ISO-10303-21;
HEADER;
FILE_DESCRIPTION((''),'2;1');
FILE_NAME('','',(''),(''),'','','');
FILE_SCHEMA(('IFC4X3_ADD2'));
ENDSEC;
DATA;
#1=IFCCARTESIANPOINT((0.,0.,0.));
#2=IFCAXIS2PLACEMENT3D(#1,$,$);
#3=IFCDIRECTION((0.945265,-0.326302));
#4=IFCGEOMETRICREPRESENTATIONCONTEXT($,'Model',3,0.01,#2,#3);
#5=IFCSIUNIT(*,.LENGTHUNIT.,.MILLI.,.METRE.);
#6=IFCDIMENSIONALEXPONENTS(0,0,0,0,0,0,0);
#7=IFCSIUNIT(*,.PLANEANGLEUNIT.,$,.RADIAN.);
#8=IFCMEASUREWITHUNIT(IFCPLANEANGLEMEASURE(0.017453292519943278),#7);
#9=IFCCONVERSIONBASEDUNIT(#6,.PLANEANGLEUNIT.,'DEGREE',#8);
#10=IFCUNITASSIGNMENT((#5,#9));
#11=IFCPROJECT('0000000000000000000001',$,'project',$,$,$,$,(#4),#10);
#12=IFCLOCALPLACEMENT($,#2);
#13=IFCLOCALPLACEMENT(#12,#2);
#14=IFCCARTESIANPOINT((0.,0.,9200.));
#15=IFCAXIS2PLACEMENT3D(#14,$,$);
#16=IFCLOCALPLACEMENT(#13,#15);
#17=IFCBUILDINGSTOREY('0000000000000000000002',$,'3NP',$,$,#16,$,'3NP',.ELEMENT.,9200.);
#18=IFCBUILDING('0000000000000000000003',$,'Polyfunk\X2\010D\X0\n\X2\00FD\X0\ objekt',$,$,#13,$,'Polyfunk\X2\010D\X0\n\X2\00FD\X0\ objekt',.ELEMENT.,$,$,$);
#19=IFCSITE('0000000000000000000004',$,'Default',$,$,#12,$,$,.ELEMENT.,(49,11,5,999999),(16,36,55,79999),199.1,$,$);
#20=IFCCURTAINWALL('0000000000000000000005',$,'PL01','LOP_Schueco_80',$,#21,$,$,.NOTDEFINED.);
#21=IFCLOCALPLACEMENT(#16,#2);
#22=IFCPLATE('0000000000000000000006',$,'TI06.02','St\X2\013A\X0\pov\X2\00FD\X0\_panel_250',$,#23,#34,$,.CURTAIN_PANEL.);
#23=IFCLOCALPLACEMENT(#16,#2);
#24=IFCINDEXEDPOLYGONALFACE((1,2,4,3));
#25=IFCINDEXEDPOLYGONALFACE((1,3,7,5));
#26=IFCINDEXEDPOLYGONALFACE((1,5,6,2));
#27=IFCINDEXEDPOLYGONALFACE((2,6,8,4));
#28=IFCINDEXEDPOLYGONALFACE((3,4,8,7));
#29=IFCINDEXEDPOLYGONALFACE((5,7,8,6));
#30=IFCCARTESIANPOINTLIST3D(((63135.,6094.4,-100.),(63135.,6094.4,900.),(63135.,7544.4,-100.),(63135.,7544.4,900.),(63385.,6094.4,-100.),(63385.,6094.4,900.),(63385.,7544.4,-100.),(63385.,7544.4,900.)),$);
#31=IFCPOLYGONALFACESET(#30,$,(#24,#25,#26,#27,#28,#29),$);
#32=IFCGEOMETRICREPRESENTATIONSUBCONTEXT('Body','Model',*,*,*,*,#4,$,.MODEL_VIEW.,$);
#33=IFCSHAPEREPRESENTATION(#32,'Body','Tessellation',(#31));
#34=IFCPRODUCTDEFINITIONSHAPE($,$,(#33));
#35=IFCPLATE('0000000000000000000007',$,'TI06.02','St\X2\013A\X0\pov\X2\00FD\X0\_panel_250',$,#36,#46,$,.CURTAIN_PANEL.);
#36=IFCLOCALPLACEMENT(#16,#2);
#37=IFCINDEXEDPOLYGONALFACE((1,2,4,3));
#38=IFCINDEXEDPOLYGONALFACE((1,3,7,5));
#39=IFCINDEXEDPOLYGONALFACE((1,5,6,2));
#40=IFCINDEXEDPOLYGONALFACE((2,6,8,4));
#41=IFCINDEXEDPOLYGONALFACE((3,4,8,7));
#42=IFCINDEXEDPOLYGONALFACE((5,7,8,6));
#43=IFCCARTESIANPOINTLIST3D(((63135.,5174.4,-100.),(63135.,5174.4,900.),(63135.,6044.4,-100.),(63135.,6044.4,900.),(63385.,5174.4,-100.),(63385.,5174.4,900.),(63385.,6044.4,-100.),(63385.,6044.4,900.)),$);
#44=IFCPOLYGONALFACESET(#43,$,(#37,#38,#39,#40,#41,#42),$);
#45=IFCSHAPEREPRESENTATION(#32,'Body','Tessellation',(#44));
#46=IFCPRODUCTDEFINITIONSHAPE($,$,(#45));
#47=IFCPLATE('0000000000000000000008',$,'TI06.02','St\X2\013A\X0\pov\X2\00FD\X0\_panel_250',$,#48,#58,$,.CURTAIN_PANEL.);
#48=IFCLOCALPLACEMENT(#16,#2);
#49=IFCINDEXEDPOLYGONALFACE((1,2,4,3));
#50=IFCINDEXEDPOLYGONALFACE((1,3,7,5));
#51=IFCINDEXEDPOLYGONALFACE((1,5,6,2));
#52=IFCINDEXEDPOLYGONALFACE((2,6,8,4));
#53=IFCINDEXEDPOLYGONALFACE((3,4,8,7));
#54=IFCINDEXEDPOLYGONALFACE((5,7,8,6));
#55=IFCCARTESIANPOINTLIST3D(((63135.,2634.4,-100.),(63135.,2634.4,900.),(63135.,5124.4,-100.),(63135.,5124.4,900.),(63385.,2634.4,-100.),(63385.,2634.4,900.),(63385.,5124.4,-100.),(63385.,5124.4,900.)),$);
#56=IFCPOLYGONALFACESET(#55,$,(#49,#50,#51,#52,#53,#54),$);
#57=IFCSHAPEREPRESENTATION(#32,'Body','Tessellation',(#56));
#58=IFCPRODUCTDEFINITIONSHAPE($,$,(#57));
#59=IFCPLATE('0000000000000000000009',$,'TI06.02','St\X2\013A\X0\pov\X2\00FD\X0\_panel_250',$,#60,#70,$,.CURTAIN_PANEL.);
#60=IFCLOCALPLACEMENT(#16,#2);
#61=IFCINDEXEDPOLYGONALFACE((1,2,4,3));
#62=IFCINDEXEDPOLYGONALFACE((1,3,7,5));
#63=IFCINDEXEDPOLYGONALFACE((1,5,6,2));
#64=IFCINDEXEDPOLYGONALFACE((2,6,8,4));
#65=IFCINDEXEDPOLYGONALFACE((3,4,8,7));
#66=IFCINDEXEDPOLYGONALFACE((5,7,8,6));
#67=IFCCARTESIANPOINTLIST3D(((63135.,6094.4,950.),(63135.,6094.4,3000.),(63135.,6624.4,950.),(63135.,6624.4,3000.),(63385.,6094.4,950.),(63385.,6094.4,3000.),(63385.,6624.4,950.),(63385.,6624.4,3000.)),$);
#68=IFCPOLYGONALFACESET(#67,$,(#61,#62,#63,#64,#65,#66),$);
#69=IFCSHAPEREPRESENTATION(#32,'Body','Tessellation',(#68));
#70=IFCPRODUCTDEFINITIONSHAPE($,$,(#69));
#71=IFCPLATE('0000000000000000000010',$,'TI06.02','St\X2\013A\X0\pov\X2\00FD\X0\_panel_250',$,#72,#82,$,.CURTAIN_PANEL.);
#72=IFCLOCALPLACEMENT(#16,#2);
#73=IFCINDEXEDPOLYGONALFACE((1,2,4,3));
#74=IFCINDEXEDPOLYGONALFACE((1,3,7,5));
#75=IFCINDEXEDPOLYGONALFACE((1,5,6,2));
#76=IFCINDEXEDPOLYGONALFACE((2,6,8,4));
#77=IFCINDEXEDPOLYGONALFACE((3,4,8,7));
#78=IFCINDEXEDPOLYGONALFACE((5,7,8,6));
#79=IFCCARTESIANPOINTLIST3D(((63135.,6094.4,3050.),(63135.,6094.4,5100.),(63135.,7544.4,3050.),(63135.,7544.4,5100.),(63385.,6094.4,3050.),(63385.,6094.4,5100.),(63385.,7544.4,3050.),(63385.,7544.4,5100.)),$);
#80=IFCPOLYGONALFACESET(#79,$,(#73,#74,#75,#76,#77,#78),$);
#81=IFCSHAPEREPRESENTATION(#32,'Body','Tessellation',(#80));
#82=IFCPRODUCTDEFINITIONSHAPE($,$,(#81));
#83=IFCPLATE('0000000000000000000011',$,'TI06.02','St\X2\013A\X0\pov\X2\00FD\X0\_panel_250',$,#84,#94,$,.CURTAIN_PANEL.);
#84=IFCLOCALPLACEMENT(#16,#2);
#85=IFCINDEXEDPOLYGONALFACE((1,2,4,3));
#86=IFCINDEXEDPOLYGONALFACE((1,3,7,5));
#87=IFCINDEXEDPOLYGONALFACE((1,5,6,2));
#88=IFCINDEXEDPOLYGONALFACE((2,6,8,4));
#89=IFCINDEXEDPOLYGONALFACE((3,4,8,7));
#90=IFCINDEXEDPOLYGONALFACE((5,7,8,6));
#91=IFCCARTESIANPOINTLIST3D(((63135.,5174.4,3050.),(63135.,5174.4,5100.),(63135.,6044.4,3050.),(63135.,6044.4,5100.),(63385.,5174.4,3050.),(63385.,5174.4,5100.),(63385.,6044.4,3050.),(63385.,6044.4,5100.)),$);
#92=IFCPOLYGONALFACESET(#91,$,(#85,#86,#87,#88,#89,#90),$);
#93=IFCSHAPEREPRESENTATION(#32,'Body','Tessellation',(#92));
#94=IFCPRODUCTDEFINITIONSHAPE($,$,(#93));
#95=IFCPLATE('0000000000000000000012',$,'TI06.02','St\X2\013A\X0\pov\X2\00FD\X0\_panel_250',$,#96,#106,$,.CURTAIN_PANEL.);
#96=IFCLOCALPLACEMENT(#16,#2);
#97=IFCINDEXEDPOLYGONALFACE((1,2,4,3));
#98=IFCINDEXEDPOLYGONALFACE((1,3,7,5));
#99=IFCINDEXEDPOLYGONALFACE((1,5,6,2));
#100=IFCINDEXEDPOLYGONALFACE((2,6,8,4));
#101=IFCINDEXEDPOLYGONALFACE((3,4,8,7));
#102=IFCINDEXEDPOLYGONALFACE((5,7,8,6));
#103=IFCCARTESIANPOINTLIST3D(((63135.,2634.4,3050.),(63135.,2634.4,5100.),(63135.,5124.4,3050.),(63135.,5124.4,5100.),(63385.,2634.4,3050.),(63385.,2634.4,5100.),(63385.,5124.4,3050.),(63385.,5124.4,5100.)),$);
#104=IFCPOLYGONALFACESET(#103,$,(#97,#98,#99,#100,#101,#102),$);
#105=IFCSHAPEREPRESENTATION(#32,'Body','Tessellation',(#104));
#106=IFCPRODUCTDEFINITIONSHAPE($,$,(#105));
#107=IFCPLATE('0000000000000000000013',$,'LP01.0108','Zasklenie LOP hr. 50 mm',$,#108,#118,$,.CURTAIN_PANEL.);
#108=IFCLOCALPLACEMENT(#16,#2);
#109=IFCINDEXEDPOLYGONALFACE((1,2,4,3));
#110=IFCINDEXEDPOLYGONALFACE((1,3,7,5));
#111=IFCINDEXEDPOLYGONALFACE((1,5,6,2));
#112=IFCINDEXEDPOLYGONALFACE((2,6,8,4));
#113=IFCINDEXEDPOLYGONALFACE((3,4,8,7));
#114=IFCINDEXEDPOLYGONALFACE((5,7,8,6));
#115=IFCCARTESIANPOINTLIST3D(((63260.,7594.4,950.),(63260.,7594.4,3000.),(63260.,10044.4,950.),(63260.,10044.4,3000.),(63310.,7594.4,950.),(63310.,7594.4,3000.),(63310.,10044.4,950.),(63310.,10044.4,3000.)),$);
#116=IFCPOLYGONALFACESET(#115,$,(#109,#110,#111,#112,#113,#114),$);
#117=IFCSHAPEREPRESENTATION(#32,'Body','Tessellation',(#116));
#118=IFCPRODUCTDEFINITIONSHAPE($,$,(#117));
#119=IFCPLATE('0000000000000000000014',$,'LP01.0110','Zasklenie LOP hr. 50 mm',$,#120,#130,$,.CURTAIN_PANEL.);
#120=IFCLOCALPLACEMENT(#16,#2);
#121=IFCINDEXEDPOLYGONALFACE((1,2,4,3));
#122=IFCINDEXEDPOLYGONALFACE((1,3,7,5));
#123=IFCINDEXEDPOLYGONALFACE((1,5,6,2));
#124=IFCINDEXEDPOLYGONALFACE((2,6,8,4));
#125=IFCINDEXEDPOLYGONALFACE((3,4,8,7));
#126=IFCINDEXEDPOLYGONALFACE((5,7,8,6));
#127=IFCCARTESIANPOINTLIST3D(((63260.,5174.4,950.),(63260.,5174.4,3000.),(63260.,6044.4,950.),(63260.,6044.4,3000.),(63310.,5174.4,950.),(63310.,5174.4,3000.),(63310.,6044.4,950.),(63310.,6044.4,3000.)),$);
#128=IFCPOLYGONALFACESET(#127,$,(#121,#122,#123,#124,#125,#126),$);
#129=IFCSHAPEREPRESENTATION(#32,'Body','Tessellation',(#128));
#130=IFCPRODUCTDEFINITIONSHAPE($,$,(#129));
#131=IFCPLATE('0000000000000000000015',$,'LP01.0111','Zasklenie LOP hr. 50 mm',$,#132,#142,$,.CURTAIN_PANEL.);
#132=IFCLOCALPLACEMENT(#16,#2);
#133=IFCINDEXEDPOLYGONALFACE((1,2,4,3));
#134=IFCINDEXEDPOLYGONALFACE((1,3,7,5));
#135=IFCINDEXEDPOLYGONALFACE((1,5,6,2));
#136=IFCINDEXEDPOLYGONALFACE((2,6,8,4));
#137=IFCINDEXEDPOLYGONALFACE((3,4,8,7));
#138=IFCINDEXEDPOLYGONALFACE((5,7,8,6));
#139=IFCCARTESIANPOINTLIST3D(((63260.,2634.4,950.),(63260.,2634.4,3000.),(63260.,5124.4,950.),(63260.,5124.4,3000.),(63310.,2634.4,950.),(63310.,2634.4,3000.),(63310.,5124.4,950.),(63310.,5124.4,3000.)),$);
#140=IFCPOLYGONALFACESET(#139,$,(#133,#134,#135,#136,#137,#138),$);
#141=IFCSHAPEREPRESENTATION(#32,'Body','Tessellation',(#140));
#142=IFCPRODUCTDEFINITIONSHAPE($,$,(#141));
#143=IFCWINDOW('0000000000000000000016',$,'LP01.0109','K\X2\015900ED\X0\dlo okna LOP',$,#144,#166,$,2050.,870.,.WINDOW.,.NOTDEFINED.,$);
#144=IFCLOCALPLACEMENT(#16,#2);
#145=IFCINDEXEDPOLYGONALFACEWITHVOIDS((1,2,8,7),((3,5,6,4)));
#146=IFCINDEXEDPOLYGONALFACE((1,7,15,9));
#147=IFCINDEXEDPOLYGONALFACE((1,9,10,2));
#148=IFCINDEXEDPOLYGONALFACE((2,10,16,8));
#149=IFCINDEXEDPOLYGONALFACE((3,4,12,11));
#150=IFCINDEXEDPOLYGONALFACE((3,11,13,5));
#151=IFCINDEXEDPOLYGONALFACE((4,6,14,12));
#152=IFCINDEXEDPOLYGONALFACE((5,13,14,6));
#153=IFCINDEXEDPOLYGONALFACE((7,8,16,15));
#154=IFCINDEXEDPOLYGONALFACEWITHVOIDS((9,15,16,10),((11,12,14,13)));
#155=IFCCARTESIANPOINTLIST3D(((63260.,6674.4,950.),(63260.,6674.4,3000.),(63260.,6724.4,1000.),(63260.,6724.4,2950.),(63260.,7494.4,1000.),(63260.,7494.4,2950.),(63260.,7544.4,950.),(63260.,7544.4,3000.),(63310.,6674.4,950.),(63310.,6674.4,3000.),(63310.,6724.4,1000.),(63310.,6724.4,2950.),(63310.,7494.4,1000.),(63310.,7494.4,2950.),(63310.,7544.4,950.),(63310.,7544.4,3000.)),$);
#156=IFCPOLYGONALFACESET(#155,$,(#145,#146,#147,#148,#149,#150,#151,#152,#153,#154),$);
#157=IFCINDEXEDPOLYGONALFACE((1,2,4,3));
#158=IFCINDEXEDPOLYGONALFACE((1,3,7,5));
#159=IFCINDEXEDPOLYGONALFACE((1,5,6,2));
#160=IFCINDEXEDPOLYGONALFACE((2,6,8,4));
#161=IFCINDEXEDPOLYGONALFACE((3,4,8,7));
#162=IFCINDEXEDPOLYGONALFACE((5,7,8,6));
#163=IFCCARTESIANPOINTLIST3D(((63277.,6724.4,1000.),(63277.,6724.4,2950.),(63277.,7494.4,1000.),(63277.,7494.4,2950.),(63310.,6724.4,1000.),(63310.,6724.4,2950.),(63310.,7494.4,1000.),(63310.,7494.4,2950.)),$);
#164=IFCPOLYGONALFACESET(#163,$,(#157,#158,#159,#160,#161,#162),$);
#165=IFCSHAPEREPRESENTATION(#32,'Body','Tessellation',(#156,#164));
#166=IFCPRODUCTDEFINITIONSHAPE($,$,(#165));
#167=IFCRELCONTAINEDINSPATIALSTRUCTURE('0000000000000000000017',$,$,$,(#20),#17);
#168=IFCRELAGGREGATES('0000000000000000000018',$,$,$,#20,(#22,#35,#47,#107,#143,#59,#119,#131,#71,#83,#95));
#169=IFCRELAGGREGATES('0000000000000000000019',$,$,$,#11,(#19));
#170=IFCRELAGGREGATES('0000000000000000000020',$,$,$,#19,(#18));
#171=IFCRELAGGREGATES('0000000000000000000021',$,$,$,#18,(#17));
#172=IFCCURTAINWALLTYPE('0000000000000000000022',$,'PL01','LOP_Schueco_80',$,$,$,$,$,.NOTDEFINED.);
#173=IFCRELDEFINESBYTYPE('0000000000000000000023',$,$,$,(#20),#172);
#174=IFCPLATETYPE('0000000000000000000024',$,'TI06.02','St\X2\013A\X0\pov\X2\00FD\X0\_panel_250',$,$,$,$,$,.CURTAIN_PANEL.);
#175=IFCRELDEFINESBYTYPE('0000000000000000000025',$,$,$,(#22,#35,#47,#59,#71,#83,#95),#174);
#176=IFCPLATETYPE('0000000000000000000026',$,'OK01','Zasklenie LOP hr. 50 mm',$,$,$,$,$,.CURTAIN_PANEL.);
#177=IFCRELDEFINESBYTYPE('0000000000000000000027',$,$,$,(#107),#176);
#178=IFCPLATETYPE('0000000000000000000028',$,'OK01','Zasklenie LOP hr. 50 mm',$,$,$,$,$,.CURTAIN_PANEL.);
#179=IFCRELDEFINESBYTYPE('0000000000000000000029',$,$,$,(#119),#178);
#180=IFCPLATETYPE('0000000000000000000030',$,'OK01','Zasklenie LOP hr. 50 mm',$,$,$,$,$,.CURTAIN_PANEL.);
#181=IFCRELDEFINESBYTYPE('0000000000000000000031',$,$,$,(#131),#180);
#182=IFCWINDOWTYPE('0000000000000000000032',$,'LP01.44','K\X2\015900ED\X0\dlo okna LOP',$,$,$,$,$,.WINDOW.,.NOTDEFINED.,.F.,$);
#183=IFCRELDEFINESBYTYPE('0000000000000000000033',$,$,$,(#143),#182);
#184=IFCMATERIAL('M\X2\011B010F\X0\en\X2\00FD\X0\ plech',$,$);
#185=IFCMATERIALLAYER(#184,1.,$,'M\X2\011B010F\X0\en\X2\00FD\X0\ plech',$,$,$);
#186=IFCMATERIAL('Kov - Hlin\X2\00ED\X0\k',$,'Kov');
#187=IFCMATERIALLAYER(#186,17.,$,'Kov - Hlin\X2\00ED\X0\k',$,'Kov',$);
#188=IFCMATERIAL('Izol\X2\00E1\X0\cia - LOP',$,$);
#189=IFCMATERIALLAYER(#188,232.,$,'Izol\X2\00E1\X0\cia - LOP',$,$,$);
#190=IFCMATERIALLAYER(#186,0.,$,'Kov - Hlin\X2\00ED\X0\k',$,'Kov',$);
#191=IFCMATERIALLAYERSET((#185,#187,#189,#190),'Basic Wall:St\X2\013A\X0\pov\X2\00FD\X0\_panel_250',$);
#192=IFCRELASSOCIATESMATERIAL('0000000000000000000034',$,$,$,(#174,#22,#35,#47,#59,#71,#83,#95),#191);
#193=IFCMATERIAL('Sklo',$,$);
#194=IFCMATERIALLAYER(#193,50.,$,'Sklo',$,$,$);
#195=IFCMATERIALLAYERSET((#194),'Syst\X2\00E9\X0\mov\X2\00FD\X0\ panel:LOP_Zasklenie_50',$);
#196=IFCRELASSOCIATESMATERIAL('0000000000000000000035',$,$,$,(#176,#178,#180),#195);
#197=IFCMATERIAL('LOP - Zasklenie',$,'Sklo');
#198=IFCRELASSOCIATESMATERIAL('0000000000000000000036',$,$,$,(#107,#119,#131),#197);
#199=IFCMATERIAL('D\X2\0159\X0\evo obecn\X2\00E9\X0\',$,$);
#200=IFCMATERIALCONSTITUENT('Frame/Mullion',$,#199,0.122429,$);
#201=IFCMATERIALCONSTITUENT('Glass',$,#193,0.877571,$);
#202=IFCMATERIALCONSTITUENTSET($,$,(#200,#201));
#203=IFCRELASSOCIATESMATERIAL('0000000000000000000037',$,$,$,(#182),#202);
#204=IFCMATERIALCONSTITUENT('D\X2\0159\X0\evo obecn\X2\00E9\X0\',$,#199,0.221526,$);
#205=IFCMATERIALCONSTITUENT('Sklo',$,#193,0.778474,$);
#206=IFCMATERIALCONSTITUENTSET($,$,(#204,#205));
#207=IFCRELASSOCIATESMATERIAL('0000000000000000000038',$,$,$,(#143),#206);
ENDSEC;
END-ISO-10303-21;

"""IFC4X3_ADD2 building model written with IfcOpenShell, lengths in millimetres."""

from ifc_helpers import new_model, entity, si_unit, converted_unit, direction, frame, frame_2d, origin, origin_2d_with_axis, place, context, subcontext, project, spatial, polyline, rectangle, outline, extrude, source, transform, mapped, material, layer, layer_set, layer_usage, constituent, constituent_set, type_object, type_shapes, element, aggregate, save


model = new_model("IFC4X3_ADD2")

# Units and contexts
model_context = context("Model", 3, precision=0.01, world=origin(), true_north=direction((0.945265, -0.326302)))
body_context = subcontext(model_context, "Body", "Model", "MODEL_VIEW")
ifc_project = project(units=[si_unit("LENGTHUNIT", "METRE", prefix="MILLI"), converted_unit("PLANEANGLEUNIT", "DEGREE", entity("IfcPlaneAngleMeasure", 0.017453292519943278), si_unit("PLANEANGLEUNIT", "RADIAN"), dimensions=[0, 0, 0, 0, 0, 0, 0])], contexts=[model_context])

# Site, building, storey
site_placement = place(None, origin())
site = spatial("IfcSite", under=ifc_project, at=site_placement, Name="Default", CompositionType="ELEMENT", RefLatitude=(49, 11, 5, 999999), RefLongitude=(16, 36, 55, 79999), RefElevation=199.1)
building_placement = place(site_placement, origin())
building = spatial("IfcBuilding", under=site, at=building_placement, Name="Polyfunkčný objekt", LongName="Polyfunkčný objekt", CompositionType="ELEMENT")
storey_placement = place(building_placement, frame((0.0, 0.0, 9200.0)))
storey = spatial("IfcBuildingStorey", under=building, at=storey_placement, Name="3NP", LongName="3NP", CompositionType="ELEMENT", Elevation=9200.0)

# Curtain wall, plates, window
curtain_wall_type = type_object("IfcCurtainWallType", Name="PL01", Description="LOP_Schueco_80", PredefinedType="NOTDEFINED")
curtain_wall_placement = place(storey_placement, frame((0.0, 0.0, -9200.0)))
curtain_wall = element("IfcCurtainWall", 1, at=curtain_wall_placement, inside=storey, type_object=curtain_wall_type, Name="PL01", Description="LOP_Schueco_80", PredefinedType="NOTDEFINED")
ifc_material_1 = material(Name="Měďený plech")
ifc_layer_1 = layer(ifc_material_1, 1.0, Name="Měďený plech")
ifc_material_2 = material(Name="Kov - Hliník", Category="Kov")
ifc_layer_2 = layer(ifc_material_2, 17.0, Name="Kov - Hliník", Category="Kov")
ifc_material_3 = material(Name="Izolácia - LOP")
ifc_layer_3 = layer(ifc_material_3, 232.0, Name="Izolácia - LOP")
ifc_layer_4 = layer(ifc_material_2, 0.0, Name="Kov - Hliník", Category="Kov")
ifc_layer_set_1 = layer_set([ifc_layer_1, ifc_layer_2, ifc_layer_3, ifc_layer_4], Name="Basic Wall:Stĺpový_panel_250")
ifc_layer_usage_1 = layer_usage(ifc_layer_set_1, "AXIS2", "NEGATIVE", 125.0)
plate_type_1 = type_object("IfcPlateType", Name="TI06.02", Description="Stĺpový_panel_250", PredefinedType="CURTAIN_PANEL", material=ifc_layer_set_1)
plate_1_placement = place(storey_placement, frame((63260.0, 7544.4, -100.0), z_axis=(0.0, 0.0, 1.0), x_axis=(0.0, -1.0, 0.0)))
plate_1 = element("IfcPlate", 2, at=plate_1_placement, type_object=plate_type_1, material=ifc_layer_usage_1, Name="TI06.02", Description="Stĺpový_panel_250", PredefinedType="CURTAIN_PANEL", context=body_context, shape_type="SweptSolid", body=[
    extrude(rectangle(XDim=250.0, YDim=1450.0, at=frame_2d((0.0, 0.0), x_axis=(1.0, 0.0))), frame((725.0, 0.0, 0.0), z_axis=(0.0, 0.0, 1.0), x_axis=(0.0, 1.0, 0.0)), (0.0, 0.0, 1.0), 1000.0),
])
ifc_layer_usage_2 = layer_usage(ifc_layer_set_1, "AXIS2", "NEGATIVE", 125.0)
plate_2_placement = place(storey_placement, frame((63260.0, 6044.4, -100.0), z_axis=(0.0, 0.0, 1.0), x_axis=(0.0, -1.0, 0.0)))
plate_2 = element("IfcPlate", 3, at=plate_2_placement, type_object=plate_type_1, material=ifc_layer_usage_2, Name="TI06.02", Description="Stĺpový_panel_250", PredefinedType="CURTAIN_PANEL", context=body_context, shape_type="SweptSolid", body=[
    extrude(rectangle(XDim=250.0, YDim=870.0, at=frame_2d((0.0, 0.0), x_axis=(1.0, 0.0))), frame((435.0, 0.0, 0.0), z_axis=(0.0, 0.0, 1.0), x_axis=(0.0, 1.0, 0.0)), (0.0, 0.0, 1.0), 1000.0),
])
ifc_layer_usage_3 = layer_usage(ifc_layer_set_1, "AXIS2", "NEGATIVE", 125.0)
plate_3_placement = place(storey_placement, frame((63260.0, 5124.4, -100.0), z_axis=(0.0, 0.0, 1.0), x_axis=(0.0, -1.0, 0.0)))
plate_3 = element("IfcPlate", 4, at=plate_3_placement, type_object=plate_type_1, material=ifc_layer_usage_3, Name="TI06.02", Description="Stĺpový_panel_250", PredefinedType="CURTAIN_PANEL", context=body_context, shape_type="SweptSolid", body=[
    extrude(rectangle(XDim=250.0, YDim=2490.0, at=origin_2d_with_axis()), frame((1245.0, 0.0, 0.0), z_axis=(0.0, 0.0, 1.0), x_axis=(0.0, 1.0, 0.0)), (0.0, 0.0, 1.0), 1000.0),
])
ifc_layer_usage_4 = layer_usage(ifc_layer_set_1, "AXIS2", "NEGATIVE", 125.0)
plate_4_placement = place(storey_placement, frame((63260.0, 6624.4, 950.0), z_axis=(0.0, 0.0, 1.0), x_axis=(0.0, -1.0, 0.0)))
plate_4 = element("IfcPlate", 5, at=plate_4_placement, type_object=plate_type_1, material=ifc_layer_usage_4, Name="TI06.02", Description="Stĺpový_panel_250", PredefinedType="CURTAIN_PANEL", context=body_context, shape_type="SweptSolid", body=[
    extrude(rectangle(XDim=250.0, YDim=530.0, at=frame_2d((0.0, 0.0), x_axis=(1.0, 0.0))), frame((265.0, 0.0, 0.0), z_axis=(0.0, 0.0, 1.0), x_axis=(0.0, 1.0, 0.0)), (0.0, 0.0, 1.0), 2050.0),
])
ifc_layer_usage_5 = layer_usage(ifc_layer_set_1, "AXIS2", "NEGATIVE", 125.0)
plate_5_placement = place(storey_placement, frame((63260.0, 7544.4, 3050.0), z_axis=(0.0, 0.0, 1.0), x_axis=(0.0, -1.0, 0.0)))
plate_5 = element("IfcPlate", 6, at=plate_5_placement, type_object=plate_type_1, material=ifc_layer_usage_5, Name="TI06.02", Description="Stĺpový_panel_250", PredefinedType="CURTAIN_PANEL", context=body_context, shape_type="SweptSolid", body=[
    extrude(rectangle(XDim=250.0, YDim=1450.0, at=frame_2d((0.0, 0.0), x_axis=(1.0, 0.0))), frame((725.0, 0.0, 0.0), z_axis=(0.0, 0.0, 1.0), x_axis=(0.0, 1.0, 0.0)), (0.0, 0.0, 1.0), 2050.0),
])
ifc_layer_usage_6 = layer_usage(ifc_layer_set_1, "AXIS2", "NEGATIVE", 125.0)
plate_6_placement = place(storey_placement, frame((63260.0, 6044.4, 3050.0), z_axis=(0.0, 0.0, 1.0), x_axis=(0.0, -1.0, 0.0)))
plate_6 = element("IfcPlate", 7, at=plate_6_placement, type_object=plate_type_1, material=ifc_layer_usage_6, Name="TI06.02", Description="Stĺpový_panel_250", PredefinedType="CURTAIN_PANEL", context=body_context, shape_type="SweptSolid", body=[
    extrude(rectangle(XDim=250.0, YDim=870.0, at=frame_2d((0.0, 0.0), x_axis=(1.0, 0.0))), frame((435.0, 0.0, 0.0), z_axis=(0.0, 0.0, 1.0), x_axis=(0.0, 1.0, 0.0)), (0.0, 0.0, 1.0), 2050.0),
])
ifc_layer_usage_7 = layer_usage(ifc_layer_set_1, "AXIS2", "NEGATIVE", 125.0)
plate_7_placement = place(storey_placement, frame((63260.0, 5124.4, 3050.0), z_axis=(0.0, 0.0, 1.0), x_axis=(0.0, -1.0, 0.0)))
plate_7 = element("IfcPlate", 8, at=plate_7_placement, type_object=plate_type_1, material=ifc_layer_usage_7, Name="TI06.02", Description="Stĺpový_panel_250", PredefinedType="CURTAIN_PANEL", context=body_context, shape_type="SweptSolid", body=[
    extrude(rectangle(XDim=250.0, YDim=2490.0, at=frame_2d((0.0, 0.0), x_axis=(1.0, 0.0))), frame((1245.0, 0.0, 0.0), z_axis=(0.0, 0.0, 1.0), x_axis=(0.0, 1.0, 0.0)), (0.0, 0.0, 1.0), 2050.0),
])
ifc_material_4 = material(Name="LOP - Zasklenie", Category="Sklo")
ifc_material_5 = material(Name="Sklo")
ifc_layer_5 = layer(ifc_material_5, 50.0, Name="Sklo")
ifc_layer_set_2 = layer_set([ifc_layer_5], Name="Systémový panel:LOP_Zasklenie_50")
plate_type_2 = type_object("IfcPlateType", Name="OK01", Description="Zasklenie LOP hr. 50 mm", PredefinedType="CURTAIN_PANEL", material=ifc_layer_set_2)
shared_shape_1 = source(origin(), body_context, "Body", "SweptSolid", [
    extrude(rectangle(XDim=50.0, YDim=2450.0, at=origin_2d_with_axis()), frame((0.0, 25.0, 0.0), z_axis=(0.0, 0.0, 1.0), x_axis=(0.0, 1.0, 0.0)), (0.0, 0.0, 1.0), 2050.0),
])
type_shapes(plate_type_2, [shared_shape_1])
plate_8_placement = place(curtain_wall_placement, frame((63260.0, 8819.4, 10150.0), z_axis=(0.0, 0.0, 1.0), x_axis=(0.0, -1.0, 0.0)))
plate_8 = element("IfcPlate", 9, at=plate_8_placement, type_object=plate_type_2, material=ifc_material_4, Name="LP01.0108", Description="Zasklenie LOP hr. 50 mm", PredefinedType="CURTAIN_PANEL", context=body_context, shape_type="MappedRepresentation", body=[
    mapped(shared_shape_1, transform((0.0, 0.0, 0.0), scale=1.0)),
])
plate_type_3 = type_object("IfcPlateType", Name="OK01", Description="Zasklenie LOP hr. 50 mm", PredefinedType="CURTAIN_PANEL", material=ifc_layer_set_2)
shared_shape_2 = source(origin(), body_context, "Body", "SweptSolid", [
    extrude(rectangle(XDim=50.0, YDim=870.0, at=origin_2d_with_axis()), frame((0.0, 25.0, 0.0), z_axis=(0.0, 0.0, 1.0), x_axis=(0.0, 1.0, 0.0)), (0.0, 0.0, 1.0), 2050.0),
])
type_shapes(plate_type_3, [shared_shape_2])
plate_9_placement = place(curtain_wall_placement, frame((63260.0, 5609.4, 10150.0), z_axis=(0.0, 0.0, 1.0), x_axis=(0.0, -1.0, 0.0)))
plate_9 = element("IfcPlate", 10, at=plate_9_placement, type_object=plate_type_3, material=ifc_material_4, Name="LP01.0110", Description="Zasklenie LOP hr. 50 mm", PredefinedType="CURTAIN_PANEL", context=body_context, shape_type="MappedRepresentation", body=[
    mapped(shared_shape_2, transform((0.0, 0.0, 0.0), scale=1.0)),
])
plate_type_4 = type_object("IfcPlateType", Name="OK01", Description="Zasklenie LOP hr. 50 mm", PredefinedType="CURTAIN_PANEL", material=ifc_layer_set_2)
shared_shape_3 = source(origin(), body_context, "Body", "SweptSolid", [
    extrude(rectangle(XDim=50.0, YDim=2490.0, at=origin_2d_with_axis()), frame((0.0, 25.0, 0.0), z_axis=(0.0, 0.0, 1.0), x_axis=(0.0, 1.0, 0.0)), (0.0, 0.0, 1.0), 2050.0),
])
type_shapes(plate_type_4, [shared_shape_3])
plate_10_placement = place(curtain_wall_placement, frame((63260.0, 3879.4, 10150.0), z_axis=(0.0, 0.0, 1.0), x_axis=(0.0, -1.0, 0.0)))
plate_10 = element("IfcPlate", 11, at=plate_10_placement, type_object=plate_type_4, material=ifc_material_4, Name="LP01.0111", Description="Zasklenie LOP hr. 50 mm", PredefinedType="CURTAIN_PANEL", context=body_context, shape_type="MappedRepresentation", body=[
    mapped(shared_shape_3, transform((0.0, 0.0, 0.0), scale=1.0)),
])
ifc_material_6 = material(Name="Dřevo obecné")
ifc_constituent_1 = constituent(ifc_material_6, Name="Dřevo obecné", fraction=0.221526)
ifc_constituent_2 = constituent(ifc_material_5, Name="Sklo", fraction=0.778474)
ifc_constituent_set_1 = constituent_set(constituents=[ifc_constituent_1, ifc_constituent_2])
ifc_constituent_3 = constituent(ifc_material_6, Name="Frame/Mullion", fraction=0.122429)
ifc_constituent_4 = constituent(ifc_material_5, Name="Glass", fraction=0.877571)
ifc_constituent_set_2 = constituent_set(constituents=[ifc_constituent_3, ifc_constituent_4])
window_type = type_object("IfcWindowType", Name="LP01.44", Description="Křídlo okna LOP", ParameterTakesPrecedence=False, PartitioningType="NOTDEFINED", PredefinedType="WINDOW", material=ifc_constituent_set_2)
shared_shape_4 = source(origin(), body_context, "Body", "SweptSolid", [
    extrude(outline(polyline([(-1025.0, -435.0), (1025.0, -435.0), (1025.0, 435.0), (-1025.0, 435.0), (-1025.0, -435.0)]), holes=[polyline([(-975.0, -385.0), (-975.0, 385.0), (975.0, 385.0), (975.0, -385.0), (-975.0, -385.0)])]), frame((0.0, 0.0, 1025.0), z_axis=(0.0, 1.0, 0.0), x_axis=(0.0, 0.0, -1.0)), (0.0, 0.0, 1.0), 50.0),
    extrude(rectangle(XDim=33.0, YDim=770.0, at=origin_2d_with_axis()), frame((0.0, 33.5, 50.0), z_axis=(0.0, 0.0, 1.0), x_axis=(0.0, -1.0, 0.0)), (0.0, 0.0, 1.0), 1950.0),
])
type_shapes(window_type, [shared_shape_4])
window_placement = place(curtain_wall_placement, frame((63260.0, 7109.4, 10150.0), z_axis=(0.0, 0.0, 1.0), x_axis=(0.0, -1.0, 0.0)))
window = element("IfcWindow", 12, at=window_placement, type_object=window_type, material=ifc_constituent_set_1, Name="LP01.0109", Description="Křídlo okna LOP", OverallHeight=2050.0, OverallWidth=870.0, PartitioningType="NOTDEFINED", PredefinedType="WINDOW", context=body_context, shape_type="MappedRepresentation", body=[
    mapped(shared_shape_4, transform((0.0, 0.0, 0.0), scale=1.0)),
])
aggregate(curtain_wall, [plate_1, plate_2, plate_3, plate_8, window, plate_4, plate_9, plate_10, plate_5, plate_6, plate_7])

save(model, "model.ifc")
